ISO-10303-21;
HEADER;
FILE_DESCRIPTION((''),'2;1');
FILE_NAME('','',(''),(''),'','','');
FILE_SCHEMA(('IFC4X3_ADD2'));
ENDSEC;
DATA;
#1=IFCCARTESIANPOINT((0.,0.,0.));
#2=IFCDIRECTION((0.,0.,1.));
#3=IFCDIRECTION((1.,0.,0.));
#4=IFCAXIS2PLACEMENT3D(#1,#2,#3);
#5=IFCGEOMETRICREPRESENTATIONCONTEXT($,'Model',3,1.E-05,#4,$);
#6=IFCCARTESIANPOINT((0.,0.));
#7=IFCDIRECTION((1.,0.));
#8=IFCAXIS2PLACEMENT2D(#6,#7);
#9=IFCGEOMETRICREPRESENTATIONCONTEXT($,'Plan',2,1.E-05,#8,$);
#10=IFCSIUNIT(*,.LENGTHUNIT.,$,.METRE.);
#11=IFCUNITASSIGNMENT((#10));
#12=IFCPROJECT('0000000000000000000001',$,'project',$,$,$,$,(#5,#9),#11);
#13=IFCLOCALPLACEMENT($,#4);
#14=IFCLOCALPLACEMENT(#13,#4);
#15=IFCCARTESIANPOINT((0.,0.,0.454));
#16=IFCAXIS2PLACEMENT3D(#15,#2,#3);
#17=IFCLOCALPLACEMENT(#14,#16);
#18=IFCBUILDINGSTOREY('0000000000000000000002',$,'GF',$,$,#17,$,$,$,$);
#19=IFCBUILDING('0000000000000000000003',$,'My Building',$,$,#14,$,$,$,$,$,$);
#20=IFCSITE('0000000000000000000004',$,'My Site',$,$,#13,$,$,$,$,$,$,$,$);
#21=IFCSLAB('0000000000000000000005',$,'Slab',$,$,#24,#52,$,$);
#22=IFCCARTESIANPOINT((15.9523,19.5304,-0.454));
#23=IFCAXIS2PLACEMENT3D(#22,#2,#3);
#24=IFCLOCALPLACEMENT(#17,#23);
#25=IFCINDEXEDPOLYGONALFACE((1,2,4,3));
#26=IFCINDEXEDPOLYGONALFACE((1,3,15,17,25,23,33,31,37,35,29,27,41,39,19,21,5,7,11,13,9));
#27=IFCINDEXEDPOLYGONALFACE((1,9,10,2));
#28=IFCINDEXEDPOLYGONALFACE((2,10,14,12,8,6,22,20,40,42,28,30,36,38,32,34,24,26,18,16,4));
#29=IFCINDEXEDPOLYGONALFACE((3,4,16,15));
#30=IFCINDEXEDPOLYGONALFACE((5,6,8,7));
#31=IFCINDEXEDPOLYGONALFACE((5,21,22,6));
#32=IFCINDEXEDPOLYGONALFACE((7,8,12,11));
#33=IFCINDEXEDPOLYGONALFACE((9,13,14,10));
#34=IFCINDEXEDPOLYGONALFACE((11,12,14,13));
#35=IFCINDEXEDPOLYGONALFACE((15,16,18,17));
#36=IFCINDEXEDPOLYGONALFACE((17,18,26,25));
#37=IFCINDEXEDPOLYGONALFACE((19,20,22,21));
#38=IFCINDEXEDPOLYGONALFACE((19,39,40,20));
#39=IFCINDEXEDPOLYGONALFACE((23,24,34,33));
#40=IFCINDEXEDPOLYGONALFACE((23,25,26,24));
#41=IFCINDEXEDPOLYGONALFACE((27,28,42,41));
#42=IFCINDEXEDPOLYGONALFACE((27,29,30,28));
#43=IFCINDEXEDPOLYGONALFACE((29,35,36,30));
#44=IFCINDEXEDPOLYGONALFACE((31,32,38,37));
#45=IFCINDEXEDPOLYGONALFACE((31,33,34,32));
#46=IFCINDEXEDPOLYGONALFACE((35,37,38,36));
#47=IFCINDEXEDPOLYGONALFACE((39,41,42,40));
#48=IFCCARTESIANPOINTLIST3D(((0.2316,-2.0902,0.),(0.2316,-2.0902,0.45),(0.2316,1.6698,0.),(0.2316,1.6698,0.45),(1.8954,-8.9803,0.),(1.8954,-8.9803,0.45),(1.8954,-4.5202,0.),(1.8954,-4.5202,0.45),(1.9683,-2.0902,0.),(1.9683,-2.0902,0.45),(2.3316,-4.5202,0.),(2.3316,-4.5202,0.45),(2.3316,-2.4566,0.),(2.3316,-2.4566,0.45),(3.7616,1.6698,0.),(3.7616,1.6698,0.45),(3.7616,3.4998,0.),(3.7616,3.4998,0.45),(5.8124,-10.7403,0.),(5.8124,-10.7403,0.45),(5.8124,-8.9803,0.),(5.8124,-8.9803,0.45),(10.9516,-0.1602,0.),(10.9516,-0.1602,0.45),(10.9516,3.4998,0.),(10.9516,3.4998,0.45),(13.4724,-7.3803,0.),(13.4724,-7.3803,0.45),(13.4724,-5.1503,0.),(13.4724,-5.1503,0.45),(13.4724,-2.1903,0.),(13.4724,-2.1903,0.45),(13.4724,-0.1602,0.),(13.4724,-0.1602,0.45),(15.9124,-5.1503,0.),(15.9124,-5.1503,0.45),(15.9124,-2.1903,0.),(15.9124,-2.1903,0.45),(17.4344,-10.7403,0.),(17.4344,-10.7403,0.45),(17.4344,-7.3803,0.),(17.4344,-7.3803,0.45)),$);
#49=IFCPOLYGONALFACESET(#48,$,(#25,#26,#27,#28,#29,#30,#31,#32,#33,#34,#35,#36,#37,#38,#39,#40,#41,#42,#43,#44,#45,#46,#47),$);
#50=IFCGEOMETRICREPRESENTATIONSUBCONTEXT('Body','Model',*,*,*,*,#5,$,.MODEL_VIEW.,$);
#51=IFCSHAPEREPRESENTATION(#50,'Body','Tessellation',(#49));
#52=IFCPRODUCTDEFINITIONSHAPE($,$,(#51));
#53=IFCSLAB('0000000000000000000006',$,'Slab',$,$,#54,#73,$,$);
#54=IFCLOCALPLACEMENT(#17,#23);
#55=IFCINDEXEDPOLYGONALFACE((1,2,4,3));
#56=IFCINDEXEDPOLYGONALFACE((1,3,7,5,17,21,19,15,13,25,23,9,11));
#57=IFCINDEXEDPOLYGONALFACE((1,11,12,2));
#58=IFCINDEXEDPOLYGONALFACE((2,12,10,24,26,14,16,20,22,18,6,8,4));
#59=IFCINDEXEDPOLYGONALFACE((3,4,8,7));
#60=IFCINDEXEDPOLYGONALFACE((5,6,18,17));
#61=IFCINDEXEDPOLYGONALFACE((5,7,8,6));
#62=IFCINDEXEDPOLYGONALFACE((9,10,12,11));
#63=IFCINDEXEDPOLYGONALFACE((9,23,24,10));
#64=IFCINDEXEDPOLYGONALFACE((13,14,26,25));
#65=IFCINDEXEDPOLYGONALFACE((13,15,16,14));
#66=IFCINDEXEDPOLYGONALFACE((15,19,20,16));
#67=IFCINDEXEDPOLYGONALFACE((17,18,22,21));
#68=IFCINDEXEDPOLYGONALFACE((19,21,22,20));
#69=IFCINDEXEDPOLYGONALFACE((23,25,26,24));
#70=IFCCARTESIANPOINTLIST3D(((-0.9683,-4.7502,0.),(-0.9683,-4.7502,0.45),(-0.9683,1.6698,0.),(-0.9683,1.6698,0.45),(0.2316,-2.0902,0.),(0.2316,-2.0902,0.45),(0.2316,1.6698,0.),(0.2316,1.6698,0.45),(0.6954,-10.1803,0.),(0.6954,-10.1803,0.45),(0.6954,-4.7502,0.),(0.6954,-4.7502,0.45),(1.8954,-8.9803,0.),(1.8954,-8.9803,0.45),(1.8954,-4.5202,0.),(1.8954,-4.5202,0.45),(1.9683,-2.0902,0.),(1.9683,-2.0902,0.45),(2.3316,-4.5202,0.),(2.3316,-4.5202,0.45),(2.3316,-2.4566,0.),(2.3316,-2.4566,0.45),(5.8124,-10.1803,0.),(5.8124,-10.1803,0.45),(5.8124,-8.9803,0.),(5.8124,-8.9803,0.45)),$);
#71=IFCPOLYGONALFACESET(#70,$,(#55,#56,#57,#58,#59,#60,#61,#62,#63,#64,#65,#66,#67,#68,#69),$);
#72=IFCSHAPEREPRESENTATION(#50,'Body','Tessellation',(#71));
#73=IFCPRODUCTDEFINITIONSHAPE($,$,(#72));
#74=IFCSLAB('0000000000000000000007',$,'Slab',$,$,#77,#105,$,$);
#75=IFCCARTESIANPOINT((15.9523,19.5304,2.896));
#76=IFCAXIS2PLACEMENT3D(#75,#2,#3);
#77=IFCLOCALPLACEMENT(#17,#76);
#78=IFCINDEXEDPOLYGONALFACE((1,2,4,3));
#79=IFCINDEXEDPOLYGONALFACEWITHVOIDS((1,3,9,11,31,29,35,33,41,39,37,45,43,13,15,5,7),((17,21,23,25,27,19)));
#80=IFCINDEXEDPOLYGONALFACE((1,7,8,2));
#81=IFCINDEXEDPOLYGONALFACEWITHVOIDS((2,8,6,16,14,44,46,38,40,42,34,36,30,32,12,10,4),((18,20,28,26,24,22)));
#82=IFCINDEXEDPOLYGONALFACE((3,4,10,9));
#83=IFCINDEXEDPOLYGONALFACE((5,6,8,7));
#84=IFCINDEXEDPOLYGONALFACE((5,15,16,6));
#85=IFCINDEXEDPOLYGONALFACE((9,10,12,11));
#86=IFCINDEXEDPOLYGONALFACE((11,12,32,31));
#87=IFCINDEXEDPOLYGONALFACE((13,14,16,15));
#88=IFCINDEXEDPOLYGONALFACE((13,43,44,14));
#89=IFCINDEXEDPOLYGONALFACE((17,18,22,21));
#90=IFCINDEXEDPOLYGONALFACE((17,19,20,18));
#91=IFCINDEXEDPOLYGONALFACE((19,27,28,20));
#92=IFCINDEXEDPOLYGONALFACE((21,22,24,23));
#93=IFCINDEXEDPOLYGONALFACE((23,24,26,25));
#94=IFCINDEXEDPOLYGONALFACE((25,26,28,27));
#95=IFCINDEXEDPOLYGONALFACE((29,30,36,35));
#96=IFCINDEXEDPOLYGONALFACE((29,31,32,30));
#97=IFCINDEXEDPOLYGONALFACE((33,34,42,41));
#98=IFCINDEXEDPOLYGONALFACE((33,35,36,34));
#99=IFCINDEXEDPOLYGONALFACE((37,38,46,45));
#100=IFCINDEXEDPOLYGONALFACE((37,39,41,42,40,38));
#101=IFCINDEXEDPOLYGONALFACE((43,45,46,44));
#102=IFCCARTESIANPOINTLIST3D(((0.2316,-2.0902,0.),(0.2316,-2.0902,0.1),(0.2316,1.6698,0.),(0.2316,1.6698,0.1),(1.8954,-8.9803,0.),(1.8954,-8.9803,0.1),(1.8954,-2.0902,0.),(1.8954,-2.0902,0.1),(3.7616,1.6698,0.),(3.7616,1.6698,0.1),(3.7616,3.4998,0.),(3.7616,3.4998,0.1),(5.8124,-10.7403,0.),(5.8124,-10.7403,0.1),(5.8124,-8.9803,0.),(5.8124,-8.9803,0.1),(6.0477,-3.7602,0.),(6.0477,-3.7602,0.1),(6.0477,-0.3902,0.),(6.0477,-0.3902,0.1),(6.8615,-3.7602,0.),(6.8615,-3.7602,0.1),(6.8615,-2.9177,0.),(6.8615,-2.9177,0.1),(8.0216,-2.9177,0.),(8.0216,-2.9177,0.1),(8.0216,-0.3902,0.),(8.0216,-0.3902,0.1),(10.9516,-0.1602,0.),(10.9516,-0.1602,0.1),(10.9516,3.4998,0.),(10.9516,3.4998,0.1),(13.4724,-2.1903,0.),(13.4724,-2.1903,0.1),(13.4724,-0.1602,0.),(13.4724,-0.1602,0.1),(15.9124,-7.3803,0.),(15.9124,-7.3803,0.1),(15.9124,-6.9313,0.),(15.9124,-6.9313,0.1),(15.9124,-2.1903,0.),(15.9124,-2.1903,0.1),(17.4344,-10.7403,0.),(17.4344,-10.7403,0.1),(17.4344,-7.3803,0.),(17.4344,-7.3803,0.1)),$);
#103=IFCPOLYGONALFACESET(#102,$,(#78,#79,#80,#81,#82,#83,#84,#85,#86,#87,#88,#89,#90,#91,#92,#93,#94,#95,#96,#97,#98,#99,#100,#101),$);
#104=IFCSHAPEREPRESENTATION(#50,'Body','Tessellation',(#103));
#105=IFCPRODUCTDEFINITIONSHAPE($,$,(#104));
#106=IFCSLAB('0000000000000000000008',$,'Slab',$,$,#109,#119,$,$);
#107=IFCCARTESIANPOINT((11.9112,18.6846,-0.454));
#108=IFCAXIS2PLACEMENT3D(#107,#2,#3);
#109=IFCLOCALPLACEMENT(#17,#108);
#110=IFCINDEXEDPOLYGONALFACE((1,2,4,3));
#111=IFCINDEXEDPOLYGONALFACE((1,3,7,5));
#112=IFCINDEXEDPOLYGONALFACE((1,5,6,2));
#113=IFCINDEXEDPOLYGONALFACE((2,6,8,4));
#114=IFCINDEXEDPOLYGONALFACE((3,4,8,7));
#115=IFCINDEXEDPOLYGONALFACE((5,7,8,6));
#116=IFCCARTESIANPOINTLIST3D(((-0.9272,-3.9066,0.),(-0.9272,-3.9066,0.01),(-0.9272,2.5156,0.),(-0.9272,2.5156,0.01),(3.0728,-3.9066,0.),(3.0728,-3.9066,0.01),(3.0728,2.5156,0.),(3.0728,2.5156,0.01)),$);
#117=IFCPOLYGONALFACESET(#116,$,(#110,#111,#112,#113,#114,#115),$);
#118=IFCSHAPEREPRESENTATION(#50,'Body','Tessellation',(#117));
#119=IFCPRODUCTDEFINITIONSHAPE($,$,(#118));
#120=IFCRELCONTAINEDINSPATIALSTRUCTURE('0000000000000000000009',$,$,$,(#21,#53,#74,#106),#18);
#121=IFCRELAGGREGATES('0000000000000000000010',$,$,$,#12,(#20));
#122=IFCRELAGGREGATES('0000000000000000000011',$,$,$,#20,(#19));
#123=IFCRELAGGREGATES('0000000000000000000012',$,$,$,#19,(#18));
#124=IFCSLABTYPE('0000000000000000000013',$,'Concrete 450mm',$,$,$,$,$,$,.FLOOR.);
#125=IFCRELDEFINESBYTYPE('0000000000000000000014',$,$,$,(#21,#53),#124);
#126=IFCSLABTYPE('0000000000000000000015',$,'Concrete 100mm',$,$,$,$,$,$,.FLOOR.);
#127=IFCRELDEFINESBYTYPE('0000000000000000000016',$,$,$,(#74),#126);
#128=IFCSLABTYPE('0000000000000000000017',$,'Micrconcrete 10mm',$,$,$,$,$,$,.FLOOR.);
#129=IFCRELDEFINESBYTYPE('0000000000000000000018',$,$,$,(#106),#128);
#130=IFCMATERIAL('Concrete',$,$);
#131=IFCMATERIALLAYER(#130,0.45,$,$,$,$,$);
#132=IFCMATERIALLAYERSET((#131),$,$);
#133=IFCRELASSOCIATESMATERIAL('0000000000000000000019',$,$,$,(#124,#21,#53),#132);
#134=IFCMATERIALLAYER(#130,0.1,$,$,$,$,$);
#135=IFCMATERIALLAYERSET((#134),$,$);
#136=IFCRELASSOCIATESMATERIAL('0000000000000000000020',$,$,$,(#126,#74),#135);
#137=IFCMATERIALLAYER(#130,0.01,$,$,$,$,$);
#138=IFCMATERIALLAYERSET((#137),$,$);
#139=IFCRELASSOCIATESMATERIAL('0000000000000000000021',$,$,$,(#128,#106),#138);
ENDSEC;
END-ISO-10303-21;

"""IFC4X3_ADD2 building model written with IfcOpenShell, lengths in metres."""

from ifc_helpers import new_model, si_unit, frame, origin_with_axes, origin_2d_with_axis, place, context, subcontext, project, spatial, line, indexed_curve, outline, extrude, material, layer, layer_set, layer_usage, type_object, element, save


model = new_model("IFC4X3_ADD2")

# Units and contexts
model_context = context("Model", 3, precision=1e-05, world=origin_with_axes())
plan_context = context("Plan", 2, precision=1e-05, world=origin_2d_with_axis())
body_context = subcontext(model_context, "Body", "Model", "MODEL_VIEW")
ifc_project = project(units=[si_unit("LENGTHUNIT", "METRE")], contexts=[model_context, plan_context])

# Site, building, storey
site_placement = place(None, origin_with_axes())
site = spatial("IfcSite", under=ifc_project, at=site_placement, Name="My Site")
building_placement = place(site_placement, origin_with_axes())
building = spatial("IfcBuilding", under=site, at=building_placement, Name="My Building")
storey_placement = place(building_placement, frame((0.0, 0.0, 0.454), z_axis=(0.0, 0.0, 1.0), x_axis=(1.0, 0.0, 0.0)))
storey = spatial("IfcBuildingStorey", under=building, at=storey_placement, Name="GF")

# Slabs
ifc_material_1 = material(Name="Concrete")
ifc_layer_1 = layer(ifc_material_1, 0.45)
ifc_layer_set_1 = layer_set([ifc_layer_1])
ifc_layer_usage_1 = layer_usage(ifc_layer_set_1, "AXIS3", "POSITIVE", 0.0)
slab_type_1 = type_object("IfcSlabType", Name="Concrete 450mm", PredefinedType="FLOOR", material=ifc_layer_set_1)
slab_1_placement = place(storey_placement, frame((15.9523, 19.5304, -0.454), z_axis=(0.0, 0.0, 1.0), x_axis=(1.0, 0.0, 0.0)))
element("IfcSlab", 1, at=slab_1_placement, inside=storey, type_object=slab_type_1, material=ifc_layer_usage_1, Name="Slab", context=body_context, shape_type="SweptSolid", body=[
    extrude(outline(indexed_curve([(13.4724, -2.1903), (15.9124, -2.1903), (15.9124, -5.1503), (13.4724, -5.1503), (13.4724, -7.3803), (17.4344, -7.3803), (17.4344, -10.7403), (5.8124, -10.7403), (5.8124, -8.9803), (1.8954, -8.9803), (1.8954, -4.5202), (2.3316, -4.5202), (2.3316, -2.4566), (1.9683, -2.0902), (0.2316, -2.0902), (0.2316, 1.6698), (3.7616, 1.6698), (3.7616, 3.4998), (10.9516, 3.4998), (10.9516, -0.1602), (13.4724, -0.1602)], segments=[line(14, 13), line(13, 12), line(12, 11), line(11, 10), line(10, 9), line(9, 8), line(8, 7), line(7, 6), line(6, 5), line(5, 4), line(4, 3), line(3, 2), line(2, 1), line(1, 21), line(21, 20), line(20, 19), line(19, 18), line(18, 17), line(17, 16), line(16, 15), line(15, 14)], self_intersect=False)), None, (0.0, 0.0, 1.0), 0.45),
])
ifc_layer_usage_2 = layer_usage(ifc_layer_set_1, "AXIS3", "POSITIVE", 0.0)
slab_2_placement = place(storey_placement, frame((15.9523, 19.5304, -0.454), z_axis=(0.0, 0.0, 1.0), x_axis=(1.0, 0.0, 0.0)))
element("IfcSlab", 2, at=slab_2_placement, inside=storey, type_object=slab_type_1, material=ifc_layer_usage_2, Name="Slab", context=body_context, shape_type="SweptSolid", body=[
    extrude(outline(indexed_curve([(-0.9683, 1.6698), (-0.9683, -4.7502), (0.6954, -4.7502), (0.6954, -10.1803), (5.8124, -10.1803), (5.8124, -8.9803), (1.8954, -8.9803), (1.8954, -4.5202), (2.3316, -4.5202), (2.3316, -2.4566), (1.9683, -2.0902), (0.2316, -2.0902), (0.2316, 1.6698)], segments=[line(10, 9), line(9, 8), line(8, 7), line(7, 6), line(6, 5), line(5, 4), line(4, 3), line(3, 2), line(2, 1), line(1, 13), line(13, 12), line(12, 11), line(11, 10)], self_intersect=False)), None, (0.0, 0.0, 1.0), 0.45),
])
ifc_layer_2 = layer(ifc_material_1, 0.1)
ifc_layer_set_2 = layer_set([ifc_layer_2])
ifc_layer_usage_3 = layer_usage(ifc_layer_set_2, "AXIS3", "POSITIVE", 0.0)
slab_type_2 = type_object("IfcSlabType", Name="Concrete 100mm", PredefinedType="FLOOR", material=ifc_layer_set_2)
slab_3_placement = place(storey_placement, frame((15.9523, 19.5304, 2.896), z_axis=(0.0, 0.0, 1.0), x_axis=(1.0, 0.0, 0.0)))
element("IfcSlab", 3, at=slab_3_placement, inside=storey, type_object=slab_type_2, material=ifc_layer_usage_3, Name="Slab", context=body_context, shape_type="SweptSolid", body=[
    extrude(outline(indexed_curve([(1.8954, -8.9803), (1.8954, -2.0902), (0.2316, -2.0902), (0.2316, 1.6698), (3.7616, 1.6698), (3.7616, 3.4998), (10.9516, 3.4998), (10.9516, -0.1602), (13.4724, -0.1602), (13.4724, -2.1903), (15.9124, -2.1903), (15.9124, -6.9313), (15.9124, -7.3803), (17.4344, -7.3803), (17.4344, -10.7403), (5.8124, -10.7403), (5.8124, -8.9803), (6.0477, -3.7602), (6.8615, -3.7602), (6.8615, -2.9177), (8.0216, -2.9177), (8.0216, -0.3902), (6.0477, -0.3902)], segments=[line(15, 14), line(14, 13), line(13, 12), line(12, 11), line(11, 10), line(10, 9), line(9, 8), line(8, 7), line(7, 6), line(6, 5), line(5, 4), line(4, 3), line(3, 2), line(2, 1), line(1, 17), line(17, 16), line(16, 15)], self_intersect=False), holes=[indexed_curve([(1.8954, -8.9803), (1.8954, -2.0902), (0.2316, -2.0902), (0.2316, 1.6698), (3.7616, 1.6698), (3.7616, 3.4998), (10.9516, 3.4998), (10.9516, -0.1602), (13.4724, -0.1602), (13.4724, -2.1903), (15.9124, -2.1903), (15.9124, -6.9313), (15.9124, -7.3803), (17.4344, -7.3803), (17.4344, -10.7403), (5.8124, -10.7403), (5.8124, -8.9803), (6.0477, -3.7602), (6.8615, -3.7602), (6.8615, -2.9177), (8.0216, -2.9177), (8.0216, -0.3902), (6.0477, -0.3902)], segments=[line(19, 18), line(18, 23), line(23, 22), line(22, 21), line(21, 20), line(20, 19)], self_intersect=False)]), None, (0.0, 0.0, 1.0), 0.1),
])
ifc_layer_3 = layer(ifc_material_1, 0.01)
ifc_layer_set_3 = layer_set([ifc_layer_3])
ifc_layer_usage_4 = layer_usage(ifc_layer_set_3, "AXIS3", "POSITIVE", 0.0)
slab_type_3 = type_object("IfcSlabType", Name="Micrconcrete 10mm", PredefinedType="FLOOR", material=ifc_layer_set_3)
slab_4_placement = place(storey_placement, frame((11.9112, 18.6846, -0.454), z_axis=(0.0, 0.0, 1.0), x_axis=(1.0, 0.0, 0.0)))
element("IfcSlab", 4, at=slab_4_placement, inside=storey, type_object=slab_type_3, material=ifc_layer_usage_4, Name="Slab", context=body_context, shape_type="SweptSolid", body=[
    extrude(outline(indexed_curve([(3.0728, 2.5156), (3.0728, -3.9066), (-0.9272, -3.9066), (-0.9272, 2.5156)], segments=[line(3, 2), line(2, 1), line(1, 4), line(4, 3)], self_intersect=False)), None, (0.0, 0.0, 1.0), 0.01),
])

save(model, "model.ifc")
